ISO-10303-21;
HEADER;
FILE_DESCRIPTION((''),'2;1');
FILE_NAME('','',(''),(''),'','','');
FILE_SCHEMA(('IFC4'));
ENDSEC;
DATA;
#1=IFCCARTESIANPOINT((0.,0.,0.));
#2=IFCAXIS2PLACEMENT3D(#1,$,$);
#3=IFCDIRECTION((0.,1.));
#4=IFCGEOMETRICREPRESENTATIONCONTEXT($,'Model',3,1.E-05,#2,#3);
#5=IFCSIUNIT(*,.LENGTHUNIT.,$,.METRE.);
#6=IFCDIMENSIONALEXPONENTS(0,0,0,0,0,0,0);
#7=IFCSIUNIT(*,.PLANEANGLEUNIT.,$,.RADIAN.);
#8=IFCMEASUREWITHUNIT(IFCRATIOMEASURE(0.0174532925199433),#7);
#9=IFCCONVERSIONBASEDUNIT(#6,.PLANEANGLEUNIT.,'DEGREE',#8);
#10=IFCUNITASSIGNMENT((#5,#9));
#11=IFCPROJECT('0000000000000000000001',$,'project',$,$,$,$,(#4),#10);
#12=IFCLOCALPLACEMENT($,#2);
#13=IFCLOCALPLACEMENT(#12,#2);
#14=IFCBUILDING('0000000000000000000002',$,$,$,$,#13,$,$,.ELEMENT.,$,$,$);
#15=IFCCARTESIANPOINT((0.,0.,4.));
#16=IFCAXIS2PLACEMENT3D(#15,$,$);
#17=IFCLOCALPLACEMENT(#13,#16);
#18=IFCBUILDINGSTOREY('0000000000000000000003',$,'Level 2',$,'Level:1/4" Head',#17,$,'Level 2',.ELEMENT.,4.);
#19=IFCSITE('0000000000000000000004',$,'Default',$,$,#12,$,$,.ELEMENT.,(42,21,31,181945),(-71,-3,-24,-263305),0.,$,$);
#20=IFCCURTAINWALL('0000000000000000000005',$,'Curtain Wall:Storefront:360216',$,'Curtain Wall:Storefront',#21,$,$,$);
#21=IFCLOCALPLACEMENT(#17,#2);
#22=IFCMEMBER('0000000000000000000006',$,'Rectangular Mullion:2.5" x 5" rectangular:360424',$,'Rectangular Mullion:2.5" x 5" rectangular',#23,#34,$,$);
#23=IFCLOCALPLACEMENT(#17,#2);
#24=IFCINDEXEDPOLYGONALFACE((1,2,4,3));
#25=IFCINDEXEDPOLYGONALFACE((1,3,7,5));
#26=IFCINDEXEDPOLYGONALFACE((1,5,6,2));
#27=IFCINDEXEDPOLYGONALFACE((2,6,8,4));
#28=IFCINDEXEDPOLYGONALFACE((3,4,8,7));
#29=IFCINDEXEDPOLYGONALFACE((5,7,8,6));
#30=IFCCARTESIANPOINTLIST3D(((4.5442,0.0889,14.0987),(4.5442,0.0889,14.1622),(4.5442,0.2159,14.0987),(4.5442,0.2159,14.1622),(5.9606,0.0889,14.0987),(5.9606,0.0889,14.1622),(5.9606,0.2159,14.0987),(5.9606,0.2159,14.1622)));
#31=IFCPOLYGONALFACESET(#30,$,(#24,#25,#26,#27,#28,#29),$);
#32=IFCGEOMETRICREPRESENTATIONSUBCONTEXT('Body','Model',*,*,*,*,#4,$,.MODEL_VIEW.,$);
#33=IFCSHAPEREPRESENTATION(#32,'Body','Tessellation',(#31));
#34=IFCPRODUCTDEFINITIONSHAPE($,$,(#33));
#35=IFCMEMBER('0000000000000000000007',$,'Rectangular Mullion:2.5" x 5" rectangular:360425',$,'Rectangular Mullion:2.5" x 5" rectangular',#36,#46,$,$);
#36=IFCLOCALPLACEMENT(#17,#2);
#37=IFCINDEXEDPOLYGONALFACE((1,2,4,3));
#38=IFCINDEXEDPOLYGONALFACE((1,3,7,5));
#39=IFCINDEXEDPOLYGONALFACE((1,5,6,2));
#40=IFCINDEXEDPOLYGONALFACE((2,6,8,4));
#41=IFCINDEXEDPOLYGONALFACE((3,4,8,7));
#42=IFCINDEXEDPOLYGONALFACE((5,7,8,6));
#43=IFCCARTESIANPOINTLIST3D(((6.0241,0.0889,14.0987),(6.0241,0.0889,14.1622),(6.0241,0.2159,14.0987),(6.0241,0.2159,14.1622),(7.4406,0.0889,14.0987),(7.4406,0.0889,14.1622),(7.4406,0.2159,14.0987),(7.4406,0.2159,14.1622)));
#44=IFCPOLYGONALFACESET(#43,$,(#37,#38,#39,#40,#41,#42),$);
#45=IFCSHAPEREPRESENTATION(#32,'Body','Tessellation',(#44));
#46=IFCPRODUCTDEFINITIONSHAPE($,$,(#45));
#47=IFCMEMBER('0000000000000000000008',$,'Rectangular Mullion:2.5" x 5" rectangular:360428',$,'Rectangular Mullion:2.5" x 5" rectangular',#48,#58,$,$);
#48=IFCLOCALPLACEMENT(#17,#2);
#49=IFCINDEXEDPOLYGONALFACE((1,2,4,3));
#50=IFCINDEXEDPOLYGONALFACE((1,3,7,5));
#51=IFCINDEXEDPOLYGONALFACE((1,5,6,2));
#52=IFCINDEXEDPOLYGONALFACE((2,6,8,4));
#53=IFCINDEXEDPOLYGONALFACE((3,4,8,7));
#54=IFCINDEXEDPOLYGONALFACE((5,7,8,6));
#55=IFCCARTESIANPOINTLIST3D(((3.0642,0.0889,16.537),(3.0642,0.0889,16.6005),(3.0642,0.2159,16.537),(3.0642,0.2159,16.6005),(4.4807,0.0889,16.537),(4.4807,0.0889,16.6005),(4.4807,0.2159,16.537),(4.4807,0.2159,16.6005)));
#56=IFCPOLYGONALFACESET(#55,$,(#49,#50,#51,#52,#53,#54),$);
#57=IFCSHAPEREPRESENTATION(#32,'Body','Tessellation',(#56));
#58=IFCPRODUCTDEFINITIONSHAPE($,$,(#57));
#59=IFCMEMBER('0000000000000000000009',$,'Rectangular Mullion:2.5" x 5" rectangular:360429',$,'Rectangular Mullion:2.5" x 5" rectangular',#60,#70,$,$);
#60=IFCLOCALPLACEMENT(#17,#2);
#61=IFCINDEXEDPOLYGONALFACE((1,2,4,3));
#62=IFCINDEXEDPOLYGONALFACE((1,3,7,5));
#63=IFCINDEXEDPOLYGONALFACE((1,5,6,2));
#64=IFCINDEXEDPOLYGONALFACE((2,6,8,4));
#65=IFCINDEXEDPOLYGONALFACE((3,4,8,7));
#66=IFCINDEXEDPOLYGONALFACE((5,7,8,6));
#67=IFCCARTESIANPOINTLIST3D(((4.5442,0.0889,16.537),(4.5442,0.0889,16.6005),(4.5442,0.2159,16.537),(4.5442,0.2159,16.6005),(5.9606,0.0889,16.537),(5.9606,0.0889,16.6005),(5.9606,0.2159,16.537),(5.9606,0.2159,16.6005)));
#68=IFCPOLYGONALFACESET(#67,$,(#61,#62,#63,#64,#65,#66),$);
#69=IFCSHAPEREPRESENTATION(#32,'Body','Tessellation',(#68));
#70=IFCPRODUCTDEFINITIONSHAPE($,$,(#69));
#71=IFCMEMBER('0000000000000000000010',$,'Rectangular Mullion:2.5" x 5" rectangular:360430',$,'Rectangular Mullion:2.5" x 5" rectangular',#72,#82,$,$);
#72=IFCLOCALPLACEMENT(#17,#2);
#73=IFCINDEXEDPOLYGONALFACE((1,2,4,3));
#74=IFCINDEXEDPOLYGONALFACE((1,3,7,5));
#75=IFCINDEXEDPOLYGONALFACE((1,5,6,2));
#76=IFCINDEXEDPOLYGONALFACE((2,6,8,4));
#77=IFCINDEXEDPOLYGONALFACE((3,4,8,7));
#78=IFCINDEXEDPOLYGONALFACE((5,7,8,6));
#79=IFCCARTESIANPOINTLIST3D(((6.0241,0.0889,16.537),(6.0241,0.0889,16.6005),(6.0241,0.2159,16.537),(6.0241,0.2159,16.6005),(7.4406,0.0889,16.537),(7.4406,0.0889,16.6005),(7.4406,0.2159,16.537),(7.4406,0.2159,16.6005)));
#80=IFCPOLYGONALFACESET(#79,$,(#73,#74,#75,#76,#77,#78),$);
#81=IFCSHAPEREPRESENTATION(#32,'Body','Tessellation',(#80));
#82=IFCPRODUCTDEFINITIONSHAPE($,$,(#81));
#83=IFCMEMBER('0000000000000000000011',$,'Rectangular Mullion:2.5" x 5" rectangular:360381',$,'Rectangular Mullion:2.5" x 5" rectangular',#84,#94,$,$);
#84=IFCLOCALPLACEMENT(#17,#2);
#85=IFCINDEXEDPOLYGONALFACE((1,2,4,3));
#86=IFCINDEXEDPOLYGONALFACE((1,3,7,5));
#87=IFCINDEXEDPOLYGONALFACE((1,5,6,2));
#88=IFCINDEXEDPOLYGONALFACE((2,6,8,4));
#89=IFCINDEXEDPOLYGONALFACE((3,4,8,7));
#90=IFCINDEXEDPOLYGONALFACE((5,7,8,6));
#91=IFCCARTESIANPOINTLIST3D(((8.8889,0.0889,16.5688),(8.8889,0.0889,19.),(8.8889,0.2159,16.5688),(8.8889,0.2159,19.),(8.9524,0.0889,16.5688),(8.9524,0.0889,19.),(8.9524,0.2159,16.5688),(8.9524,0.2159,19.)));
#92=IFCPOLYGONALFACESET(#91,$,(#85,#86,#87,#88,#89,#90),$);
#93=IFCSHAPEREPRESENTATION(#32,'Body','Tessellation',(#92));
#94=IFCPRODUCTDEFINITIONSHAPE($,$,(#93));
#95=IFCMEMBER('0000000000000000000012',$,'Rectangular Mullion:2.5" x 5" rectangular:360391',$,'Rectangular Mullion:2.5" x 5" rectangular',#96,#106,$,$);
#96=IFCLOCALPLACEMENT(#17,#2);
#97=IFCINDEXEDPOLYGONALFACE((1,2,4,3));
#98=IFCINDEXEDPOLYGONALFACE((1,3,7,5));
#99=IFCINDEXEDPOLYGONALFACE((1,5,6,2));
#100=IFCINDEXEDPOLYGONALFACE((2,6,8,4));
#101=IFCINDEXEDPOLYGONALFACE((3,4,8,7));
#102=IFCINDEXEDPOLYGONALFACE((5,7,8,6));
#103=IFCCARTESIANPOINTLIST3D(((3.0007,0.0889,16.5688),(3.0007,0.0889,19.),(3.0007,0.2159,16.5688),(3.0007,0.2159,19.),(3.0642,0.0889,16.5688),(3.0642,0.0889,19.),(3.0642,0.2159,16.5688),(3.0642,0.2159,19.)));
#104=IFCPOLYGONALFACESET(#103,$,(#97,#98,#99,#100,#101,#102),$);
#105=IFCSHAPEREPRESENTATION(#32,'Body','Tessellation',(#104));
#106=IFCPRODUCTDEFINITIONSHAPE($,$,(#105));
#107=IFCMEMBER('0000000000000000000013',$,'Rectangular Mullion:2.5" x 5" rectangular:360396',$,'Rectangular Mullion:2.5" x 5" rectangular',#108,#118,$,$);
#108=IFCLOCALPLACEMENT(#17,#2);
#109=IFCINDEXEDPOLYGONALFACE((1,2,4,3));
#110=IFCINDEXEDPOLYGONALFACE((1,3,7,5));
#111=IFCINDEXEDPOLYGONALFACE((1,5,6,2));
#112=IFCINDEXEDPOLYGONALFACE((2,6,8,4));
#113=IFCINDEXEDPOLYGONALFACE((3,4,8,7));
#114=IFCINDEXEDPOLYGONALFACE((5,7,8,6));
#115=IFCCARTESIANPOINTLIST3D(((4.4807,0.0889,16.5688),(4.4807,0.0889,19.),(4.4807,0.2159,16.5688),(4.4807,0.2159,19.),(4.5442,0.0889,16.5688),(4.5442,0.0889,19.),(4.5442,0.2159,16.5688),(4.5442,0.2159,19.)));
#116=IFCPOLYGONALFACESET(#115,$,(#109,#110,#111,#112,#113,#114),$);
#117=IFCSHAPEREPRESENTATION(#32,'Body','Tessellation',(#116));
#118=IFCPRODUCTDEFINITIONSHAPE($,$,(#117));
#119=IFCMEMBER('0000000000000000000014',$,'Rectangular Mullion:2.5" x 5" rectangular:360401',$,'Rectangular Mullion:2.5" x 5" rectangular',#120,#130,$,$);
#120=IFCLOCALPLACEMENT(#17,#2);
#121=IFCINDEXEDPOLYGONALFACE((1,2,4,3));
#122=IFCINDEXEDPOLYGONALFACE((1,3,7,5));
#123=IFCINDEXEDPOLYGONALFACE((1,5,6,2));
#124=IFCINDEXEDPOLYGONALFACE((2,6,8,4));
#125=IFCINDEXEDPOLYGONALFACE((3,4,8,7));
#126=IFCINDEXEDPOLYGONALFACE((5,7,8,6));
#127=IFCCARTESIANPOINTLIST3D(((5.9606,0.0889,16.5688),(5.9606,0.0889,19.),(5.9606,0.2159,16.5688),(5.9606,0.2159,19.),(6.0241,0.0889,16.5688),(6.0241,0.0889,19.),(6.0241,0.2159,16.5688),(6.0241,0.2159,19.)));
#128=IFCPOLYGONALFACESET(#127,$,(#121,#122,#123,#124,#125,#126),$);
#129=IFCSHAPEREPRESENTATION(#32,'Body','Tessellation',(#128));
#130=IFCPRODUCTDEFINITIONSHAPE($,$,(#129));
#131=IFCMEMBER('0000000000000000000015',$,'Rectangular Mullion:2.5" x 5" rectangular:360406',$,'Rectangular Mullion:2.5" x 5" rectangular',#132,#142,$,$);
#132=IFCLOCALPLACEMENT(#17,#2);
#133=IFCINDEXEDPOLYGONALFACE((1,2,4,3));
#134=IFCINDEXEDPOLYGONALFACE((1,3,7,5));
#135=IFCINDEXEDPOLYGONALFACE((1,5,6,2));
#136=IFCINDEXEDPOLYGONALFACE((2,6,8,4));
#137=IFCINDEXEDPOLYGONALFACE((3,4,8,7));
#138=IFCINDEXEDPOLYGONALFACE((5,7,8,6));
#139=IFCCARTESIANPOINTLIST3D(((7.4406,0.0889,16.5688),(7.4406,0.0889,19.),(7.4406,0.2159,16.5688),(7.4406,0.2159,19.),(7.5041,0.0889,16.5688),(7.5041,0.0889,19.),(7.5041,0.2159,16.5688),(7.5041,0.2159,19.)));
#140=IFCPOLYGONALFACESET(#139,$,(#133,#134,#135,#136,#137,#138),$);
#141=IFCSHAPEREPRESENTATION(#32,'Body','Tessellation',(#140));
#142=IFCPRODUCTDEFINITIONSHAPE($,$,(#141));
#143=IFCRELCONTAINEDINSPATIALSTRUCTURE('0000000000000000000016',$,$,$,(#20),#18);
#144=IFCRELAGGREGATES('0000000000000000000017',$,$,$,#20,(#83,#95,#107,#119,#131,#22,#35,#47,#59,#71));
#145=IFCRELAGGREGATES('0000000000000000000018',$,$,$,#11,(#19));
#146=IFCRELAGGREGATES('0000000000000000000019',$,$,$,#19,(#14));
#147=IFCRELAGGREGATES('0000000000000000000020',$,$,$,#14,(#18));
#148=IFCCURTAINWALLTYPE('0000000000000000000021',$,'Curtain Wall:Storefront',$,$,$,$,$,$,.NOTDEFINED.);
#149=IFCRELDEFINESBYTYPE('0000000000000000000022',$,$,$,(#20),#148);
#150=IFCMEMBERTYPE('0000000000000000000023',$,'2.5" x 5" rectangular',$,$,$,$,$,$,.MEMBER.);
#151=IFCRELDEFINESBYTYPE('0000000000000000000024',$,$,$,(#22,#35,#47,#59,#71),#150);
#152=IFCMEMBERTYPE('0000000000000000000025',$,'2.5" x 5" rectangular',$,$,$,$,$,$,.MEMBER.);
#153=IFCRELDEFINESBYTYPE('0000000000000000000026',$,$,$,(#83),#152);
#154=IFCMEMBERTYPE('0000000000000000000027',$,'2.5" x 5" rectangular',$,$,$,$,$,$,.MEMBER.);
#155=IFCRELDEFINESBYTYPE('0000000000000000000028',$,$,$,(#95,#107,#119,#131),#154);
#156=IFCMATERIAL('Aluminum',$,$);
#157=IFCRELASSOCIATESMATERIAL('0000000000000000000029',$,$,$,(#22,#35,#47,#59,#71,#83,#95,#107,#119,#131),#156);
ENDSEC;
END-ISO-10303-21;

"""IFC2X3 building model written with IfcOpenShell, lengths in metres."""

from ifc_helpers import new_model, entity, si_unit, converted_unit, direction, frame, origin, origin_2d_with_axis, place, context, subcontext, project, spatial, rectangle, extrude, source, transform, mapped, material, type_object, type_shapes, element, aggregate, save


model = new_model("IFC2X3")

# Units and contexts
model_context = context("Model", 3, precision=1e-05, world=origin(), true_north=direction((0.0, 1.0)))
body_context = subcontext(model_context, "Body", "Model", "MODEL_VIEW")
ifc_project = project(units=[si_unit("LENGTHUNIT", "METRE"), converted_unit("PLANEANGLEUNIT", "DEGREE", entity("IfcRatioMeasure", 0.0174532925199433), si_unit("PLANEANGLEUNIT", "RADIAN"), dimensions=[0, 0, 0, 0, 0, 0, 0])], contexts=[model_context])

# Site, building, storey
site_placement = place(None, origin())
site = spatial("IfcSite", under=ifc_project, at=site_placement, Name="Default", CompositionType="ELEMENT", RefLatitude=(42, 21, 31, 181945), RefLongitude=(-71, -3, -24, -263305), RefElevation=0.0)
building_placement = place(site_placement, origin())
building = spatial("IfcBuilding", under=site, at=building_placement, CompositionType="ELEMENT")
storey_placement = place(building_placement, frame((0.0, 0.0, 4.0)))
storey = spatial("IfcBuildingStorey", under=building, at=storey_placement, Name="Level 2", ObjectType="Level:1/4\" Head", LongName="Level 2", CompositionType="ELEMENT", Elevation=4.0)

# Curtain wall, members
curtain_wall_type = type_object("IfcCurtainWallType", Name="Curtain Wall:Storefront", PredefinedType="NOTDEFINED")
curtain_wall_placement = place(storey_placement, frame((0.0, 0.0, -4.0)))
curtain_wall = element("IfcCurtainWall", 1, at=curtain_wall_placement, inside=storey, type_object=curtain_wall_type, Name="Curtain Wall:Storefront:360216", ObjectType="Curtain Wall:Storefront")
ifc_material_1 = material(Name="Aluminum")
member_type_1 = type_object("IfcMemberType", Name="2.5\" x 5\" rectangular", PredefinedType="MEMBER")
shared_shape_1 = source(origin(), body_context, "Body", "SweptSolid", [
    extrude(rectangle(XDim=0.127, YDim=0.0635, at=origin_2d_with_axis()), frame((0.0, 0.0, -1.4165), z_axis=(0.0, 0.0, 1.0), x_axis=(0.0, -1.0, 0.0)), (0.0, 0.0, 1.0), 1.4165),
])
type_shapes(member_type_1, [shared_shape_1])
member_1_placement = place(storey_placement, frame((5.9606, 0.1524, 14.1304), z_axis=(1.0, 0.0, 0.0), x_axis=(0.0, 0.0, 1.0)))
member_1 = element("IfcMember", 2, at=member_1_placement, type_object=member_type_1, material=ifc_material_1, Name="Rectangular Mullion:2.5\" x 5\" rectangular:360424", ObjectType="Rectangular Mullion:2.5\" x 5\" rectangular", context=body_context, shape_type="MappedRepresentation", body=[
    mapped(shared_shape_1, transform((0.0, 0.0, 0.0), scale=1.0)),
])
member_2_placement = place(storey_placement, frame((7.4406, 0.1524, 14.1304), z_axis=(1.0, 0.0, 0.0), x_axis=(0.0, 0.0, 1.0)))
member_2 = element("IfcMember", 3, at=member_2_placement, type_object=member_type_1, material=ifc_material_1, Name="Rectangular Mullion:2.5\" x 5\" rectangular:360425", ObjectType="Rectangular Mullion:2.5\" x 5\" rectangular", context=body_context, shape_type="MappedRepresentation", body=[
    mapped(shared_shape_1, transform((0.0, 0.0, 0.0), scale=1.0)),
])
member_3_placement = place(storey_placement, frame((4.4807, 0.1524, 16.5688), z_axis=(1.0, 0.0, 0.0), x_axis=(0.0, 0.0, 1.0)))
member_3 = element("IfcMember", 4, at=member_3_placement, type_object=member_type_1, material=ifc_material_1, Name="Rectangular Mullion:2.5\" x 5\" rectangular:360428", ObjectType="Rectangular Mullion:2.5\" x 5\" rectangular", context=body_context, shape_type="MappedRepresentation", body=[
    mapped(shared_shape_1, transform((0.0, 0.0, 0.0), scale=1.0)),
])
member_4_placement = place(storey_placement, frame((5.9606, 0.1524, 16.5688), z_axis=(1.0, 0.0, 0.0), x_axis=(0.0, 0.0, 1.0)))
member_4 = element("IfcMember", 5, at=member_4_placement, type_object=member_type_1, material=ifc_material_1, Name="Rectangular Mullion:2.5\" x 5\" rectangular:360429", ObjectType="Rectangular Mullion:2.5\" x 5\" rectangular", context=body_context, shape_type="MappedRepresentation", body=[
    mapped(shared_shape_1, transform((0.0, 0.0, 0.0), scale=1.0)),
])
member_5_placement = place(storey_placement, frame((7.4406, 0.1524, 16.5688), z_axis=(1.0, 0.0, 0.0), x_axis=(0.0, 0.0, 1.0)))
member_5 = element("IfcMember", 6, at=member_5_placement, type_object=member_type_1, material=ifc_material_1, Name="Rectangular Mullion:2.5\" x 5\" rectangular:360430", ObjectType="Rectangular Mullion:2.5\" x 5\" rectangular", context=body_context, shape_type="MappedRepresentation", body=[
    mapped(shared_shape_1, transform((0.0, 0.0, 0.0), scale=1.0)),
])
member_type_2 = type_object("IfcMemberType", Name="2.5\" x 5\" rectangular", PredefinedType="MEMBER")
shared_shape_2 = source(origin(), body_context, "Body", "SweptSolid", [
    extrude(rectangle(XDim=0.127, YDim=0.0635, at=origin_2d_with_axis()), frame((-0.0318, 0.0, -2.4312), z_axis=(0.0, 0.0, 1.0), x_axis=(0.0, -1.0, 0.0)), (0.0, 0.0, 1.0), 2.4312),
])
type_shapes(member_type_2, [shared_shape_2])
member_6_placement = place(storey_placement, frame((8.9524, 0.1524, 16.5688), z_axis=(0.0, 0.0, -1.0), x_axis=(1.0, 0.0, 0.0)))
member_6 = element("IfcMember", 7, at=member_6_placement, type_object=member_type_2, material=ifc_material_1, Name="Rectangular Mullion:2.5\" x 5\" rectangular:360381", ObjectType="Rectangular Mullion:2.5\" x 5\" rectangular", context=body_context, shape_type="MappedRepresentation", body=[
    mapped(shared_shape_2, transform((0.0, 0.0, 0.0), scale=1.0)),
])
member_type_3 = type_object("IfcMemberType", Name="2.5\" x 5\" rectangular", PredefinedType="MEMBER")
shared_shape_3 = source(origin(), body_context, "Body", "SweptSolid", [
    extrude(rectangle(XDim=0.127, YDim=0.0635, at=origin_2d_with_axis()), frame((0.0, 0.0, -2.4312), z_axis=(0.0, 0.0, 1.0), x_axis=(0.0, -1.0, 0.0)), (0.0, 0.0, 1.0), 2.4312),
])
type_shapes(member_type_3, [shared_shape_3])
member_7_placement = place(storey_placement, frame((3.0324, 0.1524, 16.5688), z_axis=(0.0, 0.0, -1.0), x_axis=(1.0, 0.0, 0.0)))
member_7 = element("IfcMember", 8, at=member_7_placement, type_object=member_type_3, material=ifc_material_1, Name="Rectangular Mullion:2.5\" x 5\" rectangular:360391", ObjectType="Rectangular Mullion:2.5\" x 5\" rectangular", context=body_context, shape_type="MappedRepresentation", body=[
    mapped(shared_shape_3, transform((0.0, 0.0, 0.0), scale=1.0)),
])
member_8_placement = place(storey_placement, frame((4.5124, 0.1524, 16.5688), z_axis=(0.0, 0.0, -1.0), x_axis=(1.0, 0.0, 0.0)))
member_8 = element("IfcMember", 9, at=member_8_placement, type_object=member_type_3, material=ifc_material_1, Name="Rectangular Mullion:2.5\" x 5\" rectangular:360396", ObjectType="Rectangular Mullion:2.5\" x 5\" rectangular", context=body_context, shape_type="MappedRepresentation", body=[
    mapped(shared_shape_3, transform((0.0, 0.0, 0.0), scale=1.0)),
])
member_9_placement = place(storey_placement, frame((5.9924, 0.1524, 16.5688), z_axis=(0.0, 0.0, -1.0), x_axis=(1.0, 0.0, 0.0)))
member_9 = element("IfcMember", 10, at=member_9_placement, type_object=member_type_3, material=ifc_material_1, Name="Rectangular Mullion:2.5\" x 5\" rectangular:360401", ObjectType="Rectangular Mullion:2.5\" x 5\" rectangular", context=body_context, shape_type="MappedRepresentation", body=[
    mapped(shared_shape_3, transform((0.0, 0.0, 0.0), scale=1.0)),
])
member_10_placement = place(storey_placement, frame((7.4724, 0.1524, 16.5688), z_axis=(0.0, 0.0, -1.0), x_axis=(1.0, 0.0, 0.0)))
member_10 = element("IfcMember", 11, at=member_10_placement, type_object=member_type_3, material=ifc_material_1, Name="Rectangular Mullion:2.5\" x 5\" rectangular:360406", ObjectType="Rectangular Mullion:2.5\" x 5\" rectangular", context=body_context, shape_type="MappedRepresentation", body=[
    mapped(shared_shape_3, transform((0.0, 0.0, 0.0), scale=1.0)),
])
aggregate(curtain_wall, [member_6, member_7, member_8, member_9, member_10, member_1, member_2, member_3, member_4, member_5])

save(model, "model.ifc")
